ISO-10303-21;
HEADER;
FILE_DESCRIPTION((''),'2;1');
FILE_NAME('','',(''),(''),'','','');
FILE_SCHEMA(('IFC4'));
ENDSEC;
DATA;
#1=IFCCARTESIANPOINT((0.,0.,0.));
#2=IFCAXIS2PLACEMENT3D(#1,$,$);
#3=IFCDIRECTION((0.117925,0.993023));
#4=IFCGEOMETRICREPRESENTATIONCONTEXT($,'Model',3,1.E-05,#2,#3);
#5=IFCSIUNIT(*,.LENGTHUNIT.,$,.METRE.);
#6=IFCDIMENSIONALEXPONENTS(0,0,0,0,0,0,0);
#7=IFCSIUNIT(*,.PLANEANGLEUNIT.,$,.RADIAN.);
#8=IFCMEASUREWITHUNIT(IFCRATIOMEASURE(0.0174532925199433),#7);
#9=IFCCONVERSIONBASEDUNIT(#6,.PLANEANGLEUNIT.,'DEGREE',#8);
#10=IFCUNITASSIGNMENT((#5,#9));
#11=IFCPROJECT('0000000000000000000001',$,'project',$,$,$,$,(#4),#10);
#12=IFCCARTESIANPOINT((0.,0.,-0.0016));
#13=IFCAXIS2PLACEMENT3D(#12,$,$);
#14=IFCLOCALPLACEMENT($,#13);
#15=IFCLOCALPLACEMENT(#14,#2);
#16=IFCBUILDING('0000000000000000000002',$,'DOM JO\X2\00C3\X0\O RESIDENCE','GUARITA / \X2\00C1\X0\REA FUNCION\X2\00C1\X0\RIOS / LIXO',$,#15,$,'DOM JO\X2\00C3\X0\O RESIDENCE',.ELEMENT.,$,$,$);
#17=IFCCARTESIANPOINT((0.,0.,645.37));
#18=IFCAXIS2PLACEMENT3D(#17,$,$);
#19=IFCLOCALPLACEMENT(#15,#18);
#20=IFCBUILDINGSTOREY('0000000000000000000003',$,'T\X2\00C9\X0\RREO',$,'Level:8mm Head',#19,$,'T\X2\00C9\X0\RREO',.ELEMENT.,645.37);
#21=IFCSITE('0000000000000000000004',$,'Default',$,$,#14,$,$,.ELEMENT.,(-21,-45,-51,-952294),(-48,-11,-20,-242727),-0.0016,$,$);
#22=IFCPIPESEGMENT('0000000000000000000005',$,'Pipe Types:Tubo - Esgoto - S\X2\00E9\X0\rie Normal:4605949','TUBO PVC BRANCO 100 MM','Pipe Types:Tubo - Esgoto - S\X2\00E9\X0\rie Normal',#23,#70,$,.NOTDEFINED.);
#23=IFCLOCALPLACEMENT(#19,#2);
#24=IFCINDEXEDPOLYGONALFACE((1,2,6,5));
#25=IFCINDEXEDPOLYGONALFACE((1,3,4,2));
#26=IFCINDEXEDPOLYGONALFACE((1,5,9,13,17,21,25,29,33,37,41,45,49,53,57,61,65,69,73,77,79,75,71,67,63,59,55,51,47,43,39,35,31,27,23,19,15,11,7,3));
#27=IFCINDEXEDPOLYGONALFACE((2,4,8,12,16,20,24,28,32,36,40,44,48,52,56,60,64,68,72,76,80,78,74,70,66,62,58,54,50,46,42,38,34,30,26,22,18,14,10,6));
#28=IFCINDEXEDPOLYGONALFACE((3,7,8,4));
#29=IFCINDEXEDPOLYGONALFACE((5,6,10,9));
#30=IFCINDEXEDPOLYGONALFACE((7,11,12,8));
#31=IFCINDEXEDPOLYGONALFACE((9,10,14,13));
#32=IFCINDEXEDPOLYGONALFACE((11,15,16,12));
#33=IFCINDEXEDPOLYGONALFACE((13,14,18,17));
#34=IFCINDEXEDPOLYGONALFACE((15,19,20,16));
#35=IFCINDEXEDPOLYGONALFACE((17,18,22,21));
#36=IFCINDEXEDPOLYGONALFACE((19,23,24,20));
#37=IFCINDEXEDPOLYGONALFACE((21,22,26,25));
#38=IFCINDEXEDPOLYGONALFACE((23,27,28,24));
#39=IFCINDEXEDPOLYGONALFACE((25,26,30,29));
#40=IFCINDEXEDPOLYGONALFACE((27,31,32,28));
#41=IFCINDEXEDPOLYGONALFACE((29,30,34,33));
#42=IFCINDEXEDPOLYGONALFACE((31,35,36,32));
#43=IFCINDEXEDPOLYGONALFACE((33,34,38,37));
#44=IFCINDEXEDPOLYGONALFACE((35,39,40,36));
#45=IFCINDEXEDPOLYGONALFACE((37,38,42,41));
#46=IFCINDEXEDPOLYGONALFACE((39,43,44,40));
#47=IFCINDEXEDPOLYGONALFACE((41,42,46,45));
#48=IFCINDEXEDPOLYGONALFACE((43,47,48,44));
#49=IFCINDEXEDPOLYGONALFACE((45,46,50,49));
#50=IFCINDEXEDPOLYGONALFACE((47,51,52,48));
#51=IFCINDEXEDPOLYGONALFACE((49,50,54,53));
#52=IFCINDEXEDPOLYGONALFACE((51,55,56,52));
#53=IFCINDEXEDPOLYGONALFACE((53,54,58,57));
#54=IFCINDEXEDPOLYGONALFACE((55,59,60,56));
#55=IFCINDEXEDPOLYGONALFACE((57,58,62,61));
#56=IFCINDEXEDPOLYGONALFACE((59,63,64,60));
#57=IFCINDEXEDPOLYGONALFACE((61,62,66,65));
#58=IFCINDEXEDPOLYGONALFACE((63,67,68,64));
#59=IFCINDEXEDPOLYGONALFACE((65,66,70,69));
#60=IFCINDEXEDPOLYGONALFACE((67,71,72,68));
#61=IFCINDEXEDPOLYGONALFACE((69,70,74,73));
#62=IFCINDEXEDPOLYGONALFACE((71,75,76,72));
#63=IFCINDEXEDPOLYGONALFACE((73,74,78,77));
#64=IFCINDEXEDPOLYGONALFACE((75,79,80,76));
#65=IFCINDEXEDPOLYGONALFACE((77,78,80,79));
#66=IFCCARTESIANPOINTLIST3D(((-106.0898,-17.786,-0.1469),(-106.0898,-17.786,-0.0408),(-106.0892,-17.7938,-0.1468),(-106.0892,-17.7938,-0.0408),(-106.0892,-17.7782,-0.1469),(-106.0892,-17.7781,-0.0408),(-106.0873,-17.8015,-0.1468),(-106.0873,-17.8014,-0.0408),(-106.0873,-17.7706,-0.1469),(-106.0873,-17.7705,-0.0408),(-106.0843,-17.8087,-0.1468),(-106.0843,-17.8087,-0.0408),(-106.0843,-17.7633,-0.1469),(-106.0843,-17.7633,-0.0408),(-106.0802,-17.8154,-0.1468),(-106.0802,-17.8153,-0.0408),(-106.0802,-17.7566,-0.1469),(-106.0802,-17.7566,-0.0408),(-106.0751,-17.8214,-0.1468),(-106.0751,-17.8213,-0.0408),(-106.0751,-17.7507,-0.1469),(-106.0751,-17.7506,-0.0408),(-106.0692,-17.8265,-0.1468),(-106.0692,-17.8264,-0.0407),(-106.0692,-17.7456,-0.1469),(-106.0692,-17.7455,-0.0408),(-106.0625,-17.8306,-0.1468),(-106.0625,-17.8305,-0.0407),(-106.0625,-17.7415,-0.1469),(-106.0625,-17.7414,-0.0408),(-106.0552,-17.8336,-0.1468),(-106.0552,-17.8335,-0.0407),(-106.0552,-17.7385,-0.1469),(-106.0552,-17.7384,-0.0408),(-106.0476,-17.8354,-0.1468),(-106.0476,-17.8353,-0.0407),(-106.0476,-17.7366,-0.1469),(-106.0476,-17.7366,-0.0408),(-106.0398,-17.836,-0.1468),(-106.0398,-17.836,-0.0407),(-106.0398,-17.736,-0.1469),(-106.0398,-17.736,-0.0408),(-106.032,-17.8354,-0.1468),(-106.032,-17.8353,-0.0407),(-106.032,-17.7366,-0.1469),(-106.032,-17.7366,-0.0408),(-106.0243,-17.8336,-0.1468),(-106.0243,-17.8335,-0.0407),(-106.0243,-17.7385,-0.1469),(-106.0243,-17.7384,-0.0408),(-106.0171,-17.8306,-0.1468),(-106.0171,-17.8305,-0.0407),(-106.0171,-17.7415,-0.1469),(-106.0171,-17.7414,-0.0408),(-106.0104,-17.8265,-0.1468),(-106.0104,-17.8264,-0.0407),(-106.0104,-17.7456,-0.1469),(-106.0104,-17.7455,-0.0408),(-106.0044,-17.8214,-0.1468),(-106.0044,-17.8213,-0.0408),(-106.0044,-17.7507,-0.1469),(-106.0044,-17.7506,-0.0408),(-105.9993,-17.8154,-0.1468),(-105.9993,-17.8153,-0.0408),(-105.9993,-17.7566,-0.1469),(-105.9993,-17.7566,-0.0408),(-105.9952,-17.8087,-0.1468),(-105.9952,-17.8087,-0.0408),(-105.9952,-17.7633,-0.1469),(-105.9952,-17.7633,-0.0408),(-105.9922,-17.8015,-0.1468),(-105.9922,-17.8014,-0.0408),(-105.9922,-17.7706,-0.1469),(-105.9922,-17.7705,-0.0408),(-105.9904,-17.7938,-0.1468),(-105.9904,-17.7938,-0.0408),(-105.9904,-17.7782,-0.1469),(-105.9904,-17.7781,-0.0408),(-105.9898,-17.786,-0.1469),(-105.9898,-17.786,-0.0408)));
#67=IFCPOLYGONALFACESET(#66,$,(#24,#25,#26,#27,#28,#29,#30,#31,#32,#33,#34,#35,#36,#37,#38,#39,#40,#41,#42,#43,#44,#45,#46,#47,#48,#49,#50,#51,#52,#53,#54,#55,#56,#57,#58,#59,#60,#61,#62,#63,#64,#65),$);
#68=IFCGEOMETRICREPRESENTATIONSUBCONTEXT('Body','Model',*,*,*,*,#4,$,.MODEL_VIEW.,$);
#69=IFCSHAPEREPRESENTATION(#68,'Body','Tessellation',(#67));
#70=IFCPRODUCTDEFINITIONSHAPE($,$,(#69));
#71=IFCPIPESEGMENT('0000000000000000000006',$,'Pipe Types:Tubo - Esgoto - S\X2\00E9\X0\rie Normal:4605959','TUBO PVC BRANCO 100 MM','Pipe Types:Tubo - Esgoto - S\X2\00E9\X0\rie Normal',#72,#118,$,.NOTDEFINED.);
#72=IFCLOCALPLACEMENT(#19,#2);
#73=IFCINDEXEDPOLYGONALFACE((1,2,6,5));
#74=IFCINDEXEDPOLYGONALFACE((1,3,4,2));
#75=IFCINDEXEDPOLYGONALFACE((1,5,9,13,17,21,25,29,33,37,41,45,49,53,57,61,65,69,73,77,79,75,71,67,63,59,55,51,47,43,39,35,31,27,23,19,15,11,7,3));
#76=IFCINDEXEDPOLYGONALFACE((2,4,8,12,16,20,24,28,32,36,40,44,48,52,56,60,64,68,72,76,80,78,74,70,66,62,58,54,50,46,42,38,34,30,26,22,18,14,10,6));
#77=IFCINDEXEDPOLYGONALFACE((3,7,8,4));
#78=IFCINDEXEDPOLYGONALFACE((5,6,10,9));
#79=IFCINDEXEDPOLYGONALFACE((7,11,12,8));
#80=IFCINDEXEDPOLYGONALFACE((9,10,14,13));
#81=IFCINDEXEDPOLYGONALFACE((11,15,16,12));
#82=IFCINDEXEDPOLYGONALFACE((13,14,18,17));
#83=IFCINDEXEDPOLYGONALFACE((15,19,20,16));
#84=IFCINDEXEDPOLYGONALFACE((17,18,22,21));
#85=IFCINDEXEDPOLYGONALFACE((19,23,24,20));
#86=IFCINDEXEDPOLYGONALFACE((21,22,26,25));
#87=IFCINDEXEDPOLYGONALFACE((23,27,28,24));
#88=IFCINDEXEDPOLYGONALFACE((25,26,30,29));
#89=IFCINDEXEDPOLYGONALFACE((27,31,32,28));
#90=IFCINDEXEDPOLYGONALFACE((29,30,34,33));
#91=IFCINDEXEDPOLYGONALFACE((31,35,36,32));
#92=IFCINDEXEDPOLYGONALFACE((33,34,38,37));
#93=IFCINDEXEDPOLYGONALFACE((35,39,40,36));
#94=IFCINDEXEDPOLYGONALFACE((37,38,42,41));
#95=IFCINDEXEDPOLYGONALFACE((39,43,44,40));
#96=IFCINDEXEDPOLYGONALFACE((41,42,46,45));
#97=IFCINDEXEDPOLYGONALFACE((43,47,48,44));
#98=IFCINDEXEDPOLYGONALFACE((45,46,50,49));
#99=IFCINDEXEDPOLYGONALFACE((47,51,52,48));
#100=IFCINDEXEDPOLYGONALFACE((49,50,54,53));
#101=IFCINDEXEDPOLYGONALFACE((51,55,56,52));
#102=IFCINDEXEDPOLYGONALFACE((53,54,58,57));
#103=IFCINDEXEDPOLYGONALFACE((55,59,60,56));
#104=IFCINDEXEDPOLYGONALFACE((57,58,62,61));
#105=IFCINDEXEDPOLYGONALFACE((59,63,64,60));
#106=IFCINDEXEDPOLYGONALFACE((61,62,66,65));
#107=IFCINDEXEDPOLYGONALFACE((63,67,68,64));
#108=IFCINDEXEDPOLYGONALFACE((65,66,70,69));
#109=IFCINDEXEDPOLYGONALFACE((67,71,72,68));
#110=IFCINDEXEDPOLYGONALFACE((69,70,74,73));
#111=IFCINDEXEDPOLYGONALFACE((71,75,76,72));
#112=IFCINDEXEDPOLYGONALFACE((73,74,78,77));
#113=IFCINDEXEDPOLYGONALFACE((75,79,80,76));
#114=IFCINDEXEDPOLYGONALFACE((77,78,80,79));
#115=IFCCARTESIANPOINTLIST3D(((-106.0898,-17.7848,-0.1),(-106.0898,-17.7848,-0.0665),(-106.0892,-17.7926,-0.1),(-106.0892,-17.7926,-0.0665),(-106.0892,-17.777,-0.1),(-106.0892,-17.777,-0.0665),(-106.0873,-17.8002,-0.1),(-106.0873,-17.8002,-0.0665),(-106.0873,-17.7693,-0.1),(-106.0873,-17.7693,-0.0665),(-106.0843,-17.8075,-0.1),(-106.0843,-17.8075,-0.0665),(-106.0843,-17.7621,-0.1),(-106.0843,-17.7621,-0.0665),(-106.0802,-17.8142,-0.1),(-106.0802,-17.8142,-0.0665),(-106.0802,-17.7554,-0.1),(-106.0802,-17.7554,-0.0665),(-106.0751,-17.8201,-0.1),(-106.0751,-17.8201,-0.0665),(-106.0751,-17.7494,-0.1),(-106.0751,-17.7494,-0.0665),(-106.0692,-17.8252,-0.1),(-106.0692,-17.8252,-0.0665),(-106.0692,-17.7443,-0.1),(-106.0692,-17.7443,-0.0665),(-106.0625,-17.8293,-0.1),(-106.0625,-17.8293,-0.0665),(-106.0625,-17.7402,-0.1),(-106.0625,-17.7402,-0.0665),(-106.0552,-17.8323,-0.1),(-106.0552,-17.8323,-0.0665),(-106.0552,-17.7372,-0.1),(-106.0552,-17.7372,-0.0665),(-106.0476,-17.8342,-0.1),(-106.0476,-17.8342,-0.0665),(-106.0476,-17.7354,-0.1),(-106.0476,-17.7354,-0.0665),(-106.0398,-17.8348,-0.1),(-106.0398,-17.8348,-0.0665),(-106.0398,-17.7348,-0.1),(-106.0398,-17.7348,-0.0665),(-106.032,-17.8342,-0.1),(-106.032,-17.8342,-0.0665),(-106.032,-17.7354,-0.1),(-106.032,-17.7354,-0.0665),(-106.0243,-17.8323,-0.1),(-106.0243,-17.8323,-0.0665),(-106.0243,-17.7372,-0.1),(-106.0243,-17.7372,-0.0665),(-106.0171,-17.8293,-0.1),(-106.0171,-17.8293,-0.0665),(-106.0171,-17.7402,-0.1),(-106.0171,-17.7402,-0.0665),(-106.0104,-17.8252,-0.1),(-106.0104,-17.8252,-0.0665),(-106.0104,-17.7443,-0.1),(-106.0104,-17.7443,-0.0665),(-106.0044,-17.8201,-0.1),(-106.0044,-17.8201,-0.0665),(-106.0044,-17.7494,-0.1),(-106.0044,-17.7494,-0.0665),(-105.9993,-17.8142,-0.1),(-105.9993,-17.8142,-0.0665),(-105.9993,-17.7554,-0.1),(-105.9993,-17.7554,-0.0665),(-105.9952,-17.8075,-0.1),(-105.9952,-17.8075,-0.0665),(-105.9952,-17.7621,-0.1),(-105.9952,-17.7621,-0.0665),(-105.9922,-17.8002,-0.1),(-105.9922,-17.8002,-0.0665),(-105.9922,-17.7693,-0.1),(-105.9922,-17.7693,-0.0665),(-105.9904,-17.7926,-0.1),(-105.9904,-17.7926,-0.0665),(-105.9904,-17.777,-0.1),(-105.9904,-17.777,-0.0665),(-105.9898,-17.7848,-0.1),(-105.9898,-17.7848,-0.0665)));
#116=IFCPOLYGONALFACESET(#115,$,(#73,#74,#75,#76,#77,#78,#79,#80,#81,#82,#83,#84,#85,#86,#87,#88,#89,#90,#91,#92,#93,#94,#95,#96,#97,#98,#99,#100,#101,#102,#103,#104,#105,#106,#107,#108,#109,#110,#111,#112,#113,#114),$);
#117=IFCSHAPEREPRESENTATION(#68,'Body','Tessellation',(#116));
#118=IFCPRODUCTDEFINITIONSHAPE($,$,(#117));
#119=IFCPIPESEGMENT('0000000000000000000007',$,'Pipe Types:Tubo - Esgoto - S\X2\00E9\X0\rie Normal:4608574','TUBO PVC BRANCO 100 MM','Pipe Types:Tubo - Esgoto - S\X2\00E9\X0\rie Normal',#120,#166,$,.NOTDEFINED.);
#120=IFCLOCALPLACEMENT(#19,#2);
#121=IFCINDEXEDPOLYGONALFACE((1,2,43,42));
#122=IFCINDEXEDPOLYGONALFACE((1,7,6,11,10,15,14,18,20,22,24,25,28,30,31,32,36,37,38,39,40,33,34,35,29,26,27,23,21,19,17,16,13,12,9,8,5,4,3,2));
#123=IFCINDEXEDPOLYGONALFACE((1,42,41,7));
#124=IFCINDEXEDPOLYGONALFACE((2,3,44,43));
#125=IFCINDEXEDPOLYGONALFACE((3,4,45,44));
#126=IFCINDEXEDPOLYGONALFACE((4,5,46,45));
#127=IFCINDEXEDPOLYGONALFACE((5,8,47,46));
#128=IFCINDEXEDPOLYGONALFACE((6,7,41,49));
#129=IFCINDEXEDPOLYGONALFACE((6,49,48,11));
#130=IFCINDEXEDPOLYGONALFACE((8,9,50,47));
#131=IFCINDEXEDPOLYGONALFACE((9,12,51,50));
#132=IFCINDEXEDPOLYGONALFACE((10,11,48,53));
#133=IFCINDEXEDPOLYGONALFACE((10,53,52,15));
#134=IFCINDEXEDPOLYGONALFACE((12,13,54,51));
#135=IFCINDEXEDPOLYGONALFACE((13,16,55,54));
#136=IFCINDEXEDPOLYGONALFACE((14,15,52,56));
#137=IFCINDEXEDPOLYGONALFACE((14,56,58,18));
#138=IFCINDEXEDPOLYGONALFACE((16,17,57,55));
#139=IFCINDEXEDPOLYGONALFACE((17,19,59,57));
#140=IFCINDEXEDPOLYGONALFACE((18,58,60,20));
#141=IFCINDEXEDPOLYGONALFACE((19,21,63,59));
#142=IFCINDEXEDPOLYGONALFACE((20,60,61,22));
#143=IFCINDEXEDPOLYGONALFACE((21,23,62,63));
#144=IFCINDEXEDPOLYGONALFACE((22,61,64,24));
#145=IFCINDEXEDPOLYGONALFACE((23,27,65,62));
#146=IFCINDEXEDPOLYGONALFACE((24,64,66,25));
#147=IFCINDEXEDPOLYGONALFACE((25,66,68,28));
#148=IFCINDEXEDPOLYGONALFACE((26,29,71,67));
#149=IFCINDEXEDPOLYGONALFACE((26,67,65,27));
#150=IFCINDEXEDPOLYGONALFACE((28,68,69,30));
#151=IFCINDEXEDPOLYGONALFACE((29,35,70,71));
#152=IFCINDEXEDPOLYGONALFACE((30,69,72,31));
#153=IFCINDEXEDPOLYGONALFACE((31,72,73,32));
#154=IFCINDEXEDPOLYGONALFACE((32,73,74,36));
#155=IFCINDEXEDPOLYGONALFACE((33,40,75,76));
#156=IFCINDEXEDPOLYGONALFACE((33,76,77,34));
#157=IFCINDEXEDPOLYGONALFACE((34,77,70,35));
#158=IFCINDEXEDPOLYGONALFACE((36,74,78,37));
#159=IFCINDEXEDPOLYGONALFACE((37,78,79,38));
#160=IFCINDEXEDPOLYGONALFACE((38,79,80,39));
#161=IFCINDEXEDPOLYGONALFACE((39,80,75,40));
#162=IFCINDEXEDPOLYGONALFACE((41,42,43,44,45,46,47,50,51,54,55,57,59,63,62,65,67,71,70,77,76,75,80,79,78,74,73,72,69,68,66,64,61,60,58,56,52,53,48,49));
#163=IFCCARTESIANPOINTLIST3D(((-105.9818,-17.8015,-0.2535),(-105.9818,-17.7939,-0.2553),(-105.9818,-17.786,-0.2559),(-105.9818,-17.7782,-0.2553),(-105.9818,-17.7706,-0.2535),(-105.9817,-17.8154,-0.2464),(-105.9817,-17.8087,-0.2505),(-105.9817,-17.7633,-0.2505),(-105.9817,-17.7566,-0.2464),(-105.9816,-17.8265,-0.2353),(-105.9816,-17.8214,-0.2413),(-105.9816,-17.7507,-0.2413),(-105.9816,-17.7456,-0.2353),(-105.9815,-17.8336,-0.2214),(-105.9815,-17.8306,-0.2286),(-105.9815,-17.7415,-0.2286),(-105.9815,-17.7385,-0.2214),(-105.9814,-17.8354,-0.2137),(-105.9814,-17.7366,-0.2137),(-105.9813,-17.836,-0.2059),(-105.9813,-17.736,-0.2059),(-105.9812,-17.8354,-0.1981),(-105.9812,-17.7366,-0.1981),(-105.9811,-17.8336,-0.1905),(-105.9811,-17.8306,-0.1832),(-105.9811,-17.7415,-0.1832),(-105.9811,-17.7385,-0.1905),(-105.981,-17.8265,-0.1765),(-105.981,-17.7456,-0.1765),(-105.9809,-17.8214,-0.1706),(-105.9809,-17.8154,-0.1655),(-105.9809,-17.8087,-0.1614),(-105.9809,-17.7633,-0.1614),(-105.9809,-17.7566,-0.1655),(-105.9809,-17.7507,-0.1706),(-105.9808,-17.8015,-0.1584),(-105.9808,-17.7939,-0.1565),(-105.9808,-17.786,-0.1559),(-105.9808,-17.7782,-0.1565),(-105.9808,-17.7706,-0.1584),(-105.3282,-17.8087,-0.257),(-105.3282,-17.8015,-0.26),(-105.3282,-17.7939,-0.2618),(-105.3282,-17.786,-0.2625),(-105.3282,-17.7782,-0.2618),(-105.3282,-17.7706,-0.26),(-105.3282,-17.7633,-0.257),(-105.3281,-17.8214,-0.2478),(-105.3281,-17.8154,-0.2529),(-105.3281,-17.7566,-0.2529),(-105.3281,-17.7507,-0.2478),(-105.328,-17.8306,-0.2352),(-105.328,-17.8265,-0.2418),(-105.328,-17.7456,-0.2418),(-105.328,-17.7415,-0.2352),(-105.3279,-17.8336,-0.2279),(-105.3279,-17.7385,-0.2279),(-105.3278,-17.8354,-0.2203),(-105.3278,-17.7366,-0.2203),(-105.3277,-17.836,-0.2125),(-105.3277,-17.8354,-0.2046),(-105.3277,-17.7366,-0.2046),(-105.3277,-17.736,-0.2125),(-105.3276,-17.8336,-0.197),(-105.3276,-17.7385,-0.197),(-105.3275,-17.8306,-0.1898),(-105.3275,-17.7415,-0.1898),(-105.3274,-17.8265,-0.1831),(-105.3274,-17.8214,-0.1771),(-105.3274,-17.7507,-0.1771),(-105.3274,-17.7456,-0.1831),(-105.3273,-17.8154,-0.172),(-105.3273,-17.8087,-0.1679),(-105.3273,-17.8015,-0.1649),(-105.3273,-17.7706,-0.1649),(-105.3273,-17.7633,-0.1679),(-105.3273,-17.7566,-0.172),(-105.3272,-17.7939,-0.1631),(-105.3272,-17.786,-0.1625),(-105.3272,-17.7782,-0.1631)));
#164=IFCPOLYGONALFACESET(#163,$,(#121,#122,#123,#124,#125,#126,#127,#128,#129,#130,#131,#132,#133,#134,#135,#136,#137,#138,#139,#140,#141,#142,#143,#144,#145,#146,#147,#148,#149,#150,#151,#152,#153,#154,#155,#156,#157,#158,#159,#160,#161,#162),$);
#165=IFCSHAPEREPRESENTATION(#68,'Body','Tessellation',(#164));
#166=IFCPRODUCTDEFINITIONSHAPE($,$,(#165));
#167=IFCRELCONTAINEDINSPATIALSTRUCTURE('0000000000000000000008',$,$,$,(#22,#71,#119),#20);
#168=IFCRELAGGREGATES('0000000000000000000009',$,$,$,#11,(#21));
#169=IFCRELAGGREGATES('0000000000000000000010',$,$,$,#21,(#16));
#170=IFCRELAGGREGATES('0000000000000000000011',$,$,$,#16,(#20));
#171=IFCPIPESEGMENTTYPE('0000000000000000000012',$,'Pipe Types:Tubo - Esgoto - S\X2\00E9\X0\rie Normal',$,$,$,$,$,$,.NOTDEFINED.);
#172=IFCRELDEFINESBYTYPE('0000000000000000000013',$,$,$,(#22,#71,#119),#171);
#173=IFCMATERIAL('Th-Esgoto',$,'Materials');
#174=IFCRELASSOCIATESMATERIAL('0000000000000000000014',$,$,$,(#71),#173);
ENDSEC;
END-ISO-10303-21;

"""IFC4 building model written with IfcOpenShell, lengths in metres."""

from ifc_helpers import new_model, entity, si_unit, converted_unit, direction, frame, origin, place, context, subcontext, project, spatial, indexed_curve, outline, extrude, material, type_object, element, save


model = new_model("IFC4")

# Units and contexts
model_context = context("Model", 3, precision=1e-05, world=origin(), true_north=direction((0.117925, 0.993023)))
body_context = subcontext(model_context, "Body", "Model", "MODEL_VIEW")
ifc_project = project(units=[si_unit("LENGTHUNIT", "METRE"), converted_unit("PLANEANGLEUNIT", "DEGREE", entity("IfcRatioMeasure", 0.0174532925199433), si_unit("PLANEANGLEUNIT", "RADIAN"), dimensions=[0, 0, 0, 0, 0, 0, 0])], contexts=[model_context])

# Site, building, storey
site_placement = place(None, frame((0.0, 0.0, -0.0016)))
site = spatial("IfcSite", under=ifc_project, at=site_placement, Name="Default", CompositionType="ELEMENT", RefLatitude=(-21, -45, -51, -952294), RefLongitude=(-48, -11, -20, -242727), RefElevation=-0.0016)
building_placement = place(site_placement, origin())
building = spatial("IfcBuilding", under=site, at=building_placement, Name="DOM JOÃO RESIDENCE", Description="GUARITA / ÁREA FUNCIONÁRIOS / LIXO", LongName="DOM JOÃO RESIDENCE", CompositionType="ELEMENT")
storey_placement = place(building_placement, frame((0.0, 0.0, 645.37)))
storey = spatial("IfcBuildingStorey", under=building, at=storey_placement, Name="TÉRREO", ObjectType="Level:8mm Head", LongName="TÉRREO", CompositionType="ELEMENT", Elevation=645.37)

# Pipe segments
pipe_segment_type_1 = type_object("IfcPipeSegmentType", Name="Pipe Types:Tubo - Esgoto - Série Normal", PredefinedType="NOTDEFINED")
pipe_segment_1_placement = place(storey_placement, frame((-106.0914, -17.8376, -0.1469)))
element("IfcPipeSegment", 1, at=pipe_segment_1_placement, inside=storey, type_object=pipe_segment_type_1, Name="Pipe Types:Tubo - Esgoto - Série Normal:4605949", Description="TUBO PVC BRANCO 100 MM", ObjectType="Pipe Types:Tubo - Esgoto - Série Normal", PredefinedType="NOTDEFINED", context=body_context, shape_type="SweptSolid", body=[
    extrude(outline(indexed_curve([(0.05, 0.0), (0.0494, 0.0078), (0.0476, 0.0155), (0.0446, 0.0227), (0.0405, 0.0294), (0.0354, 0.0354), (0.0294, 0.0405), (0.0227, 0.0446), (0.0155, 0.0476), (0.0078, 0.0494), (0.0, 0.05), (-0.0078, 0.0494), (-0.0155, 0.0476), (-0.0227, 0.0446), (-0.0294, 0.0405), (-0.0354, 0.0354), (-0.0405, 0.0294), (-0.0446, 0.0227), (-0.0476, 0.0155), (-0.0494, 0.0078), (-0.05, 0.0), (-0.0494, -0.0078), (-0.0476, -0.0155), (-0.0446, -0.0227), (-0.0405, -0.0294), (-0.0354, -0.0354), (-0.0294, -0.0405), (-0.0227, -0.0446), (-0.0155, -0.0476), (-0.0078, -0.0494), (0.0, -0.05), (0.0078, -0.0494), (0.0155, -0.0476), (0.0227, -0.0446), (0.0294, -0.0405), (0.0354, -0.0354), (0.0405, -0.0294), (0.0446, -0.0227), (0.0476, -0.0155), (0.0494, -0.0078), (0.05, 0.0)], self_intersect=False)), frame((0.0516, 0.0516, 0.0), z_axis=(0.0, 0.00051, 1.0), x_axis=(1.0, 0.0, 0.0)), (0.0, 0.0, 1.0), 0.1061),
])
ifc_material = material(Name="Th-Esgoto", Category="Materials")
pipe_segment_2_placement = place(storey_placement, frame((-106.0914, -17.8364, -0.1)))
element("IfcPipeSegment", 2, at=pipe_segment_2_placement, inside=storey, type_object=pipe_segment_type_1, material=ifc_material, Name="Pipe Types:Tubo - Esgoto - Série Normal:4605959", Description="TUBO PVC BRANCO 100 MM", ObjectType="Pipe Types:Tubo - Esgoto - Série Normal", PredefinedType="NOTDEFINED", context=body_context, shape_type="SweptSolid", body=[
    extrude(outline(indexed_curve([(0.05, 0.0), (0.0494, 0.0078), (0.0476, 0.0155), (0.0446, 0.0227), (0.0405, 0.0294), (0.0354, 0.0354), (0.0294, 0.0405), (0.0227, 0.0446), (0.0155, 0.0476), (0.0078, 0.0494), (0.0, 0.05), (-0.0078, 0.0494), (-0.0155, 0.0476), (-0.0227, 0.0446), (-0.0294, 0.0405), (-0.0354, 0.0354), (-0.0405, 0.0294), (-0.0446, 0.0227), (-0.0476, 0.0155), (-0.0494, 0.0078), (-0.05, 0.0), (-0.0494, -0.0078), (-0.0476, -0.0155), (-0.0446, -0.0227), (-0.0405, -0.0294), (-0.0354, -0.0354), (-0.0294, -0.0405), (-0.0227, -0.0446), (-0.0155, -0.0476), (-0.0078, -0.0494), (0.0, -0.05), (0.0078, -0.0494), (0.0155, -0.0476), (0.0227, -0.0446), (0.0294, -0.0405), (0.0354, -0.0354), (0.0405, -0.0294), (0.0446, -0.0227), (0.0476, -0.0155), (0.0494, -0.0078), (0.05, 0.0)], self_intersect=False)), frame((0.0516, 0.0516, 0.0)), (0.0, 0.0, 1.0), 0.0335),
])
pipe_segment_3_placement = place(storey_placement, frame((-105.9834, -17.8376, -0.264)))
element("IfcPipeSegment", 3, at=pipe_segment_3_placement, inside=storey, type_object=pipe_segment_type_1, Name="Pipe Types:Tubo - Esgoto - Série Normal:4608574", Description="TUBO PVC BRANCO 100 MM", ObjectType="Pipe Types:Tubo - Esgoto - Série Normal", PredefinedType="NOTDEFINED", context=body_context, shape_type="SweptSolid", body=[
    extrude(outline(indexed_curve([(0.05, 0.0), (0.0494, 0.0078), (0.0476, 0.0155), (0.0446, 0.0227), (0.0405, 0.0294), (0.0354, 0.0354), (0.0294, 0.0405), (0.0227, 0.0446), (0.0155, 0.0476), (0.0078, 0.0494), (0.0, 0.05), (-0.0078, 0.0494), (-0.0155, 0.0476), (-0.0227, 0.0446), (-0.0294, 0.0405), (-0.0354, 0.0354), (-0.0405, 0.0294), (-0.0446, 0.0227), (-0.0476, 0.0155), (-0.0494, 0.0078), (-0.05, 0.0), (-0.0494, -0.0078), (-0.0476, -0.0155), (-0.0446, -0.0227), (-0.0405, -0.0294), (-0.0354, -0.0354), (-0.0294, -0.0405), (-0.0227, -0.0446), (-0.0155, -0.0476), (-0.0078, -0.0494), (0.0, -0.05), (0.0078, -0.0494), (0.0155, -0.0476), (0.0227, -0.0446), (0.0294, -0.0405), (0.0354, -0.0354), (0.0405, -0.0294), (0.0446, -0.0227), (0.0476, -0.0155), (0.0494, -0.0078), (0.05, 0.0)], self_intersect=False)), frame((0.0021, 0.0516, 0.0581), z_axis=(0.99995, 0.0, -0.01), x_axis=(0.0, -1.0, 0.0)), (0.0, 0.0, 1.0), 0.6536),
])

save(model, "model.ifc")
